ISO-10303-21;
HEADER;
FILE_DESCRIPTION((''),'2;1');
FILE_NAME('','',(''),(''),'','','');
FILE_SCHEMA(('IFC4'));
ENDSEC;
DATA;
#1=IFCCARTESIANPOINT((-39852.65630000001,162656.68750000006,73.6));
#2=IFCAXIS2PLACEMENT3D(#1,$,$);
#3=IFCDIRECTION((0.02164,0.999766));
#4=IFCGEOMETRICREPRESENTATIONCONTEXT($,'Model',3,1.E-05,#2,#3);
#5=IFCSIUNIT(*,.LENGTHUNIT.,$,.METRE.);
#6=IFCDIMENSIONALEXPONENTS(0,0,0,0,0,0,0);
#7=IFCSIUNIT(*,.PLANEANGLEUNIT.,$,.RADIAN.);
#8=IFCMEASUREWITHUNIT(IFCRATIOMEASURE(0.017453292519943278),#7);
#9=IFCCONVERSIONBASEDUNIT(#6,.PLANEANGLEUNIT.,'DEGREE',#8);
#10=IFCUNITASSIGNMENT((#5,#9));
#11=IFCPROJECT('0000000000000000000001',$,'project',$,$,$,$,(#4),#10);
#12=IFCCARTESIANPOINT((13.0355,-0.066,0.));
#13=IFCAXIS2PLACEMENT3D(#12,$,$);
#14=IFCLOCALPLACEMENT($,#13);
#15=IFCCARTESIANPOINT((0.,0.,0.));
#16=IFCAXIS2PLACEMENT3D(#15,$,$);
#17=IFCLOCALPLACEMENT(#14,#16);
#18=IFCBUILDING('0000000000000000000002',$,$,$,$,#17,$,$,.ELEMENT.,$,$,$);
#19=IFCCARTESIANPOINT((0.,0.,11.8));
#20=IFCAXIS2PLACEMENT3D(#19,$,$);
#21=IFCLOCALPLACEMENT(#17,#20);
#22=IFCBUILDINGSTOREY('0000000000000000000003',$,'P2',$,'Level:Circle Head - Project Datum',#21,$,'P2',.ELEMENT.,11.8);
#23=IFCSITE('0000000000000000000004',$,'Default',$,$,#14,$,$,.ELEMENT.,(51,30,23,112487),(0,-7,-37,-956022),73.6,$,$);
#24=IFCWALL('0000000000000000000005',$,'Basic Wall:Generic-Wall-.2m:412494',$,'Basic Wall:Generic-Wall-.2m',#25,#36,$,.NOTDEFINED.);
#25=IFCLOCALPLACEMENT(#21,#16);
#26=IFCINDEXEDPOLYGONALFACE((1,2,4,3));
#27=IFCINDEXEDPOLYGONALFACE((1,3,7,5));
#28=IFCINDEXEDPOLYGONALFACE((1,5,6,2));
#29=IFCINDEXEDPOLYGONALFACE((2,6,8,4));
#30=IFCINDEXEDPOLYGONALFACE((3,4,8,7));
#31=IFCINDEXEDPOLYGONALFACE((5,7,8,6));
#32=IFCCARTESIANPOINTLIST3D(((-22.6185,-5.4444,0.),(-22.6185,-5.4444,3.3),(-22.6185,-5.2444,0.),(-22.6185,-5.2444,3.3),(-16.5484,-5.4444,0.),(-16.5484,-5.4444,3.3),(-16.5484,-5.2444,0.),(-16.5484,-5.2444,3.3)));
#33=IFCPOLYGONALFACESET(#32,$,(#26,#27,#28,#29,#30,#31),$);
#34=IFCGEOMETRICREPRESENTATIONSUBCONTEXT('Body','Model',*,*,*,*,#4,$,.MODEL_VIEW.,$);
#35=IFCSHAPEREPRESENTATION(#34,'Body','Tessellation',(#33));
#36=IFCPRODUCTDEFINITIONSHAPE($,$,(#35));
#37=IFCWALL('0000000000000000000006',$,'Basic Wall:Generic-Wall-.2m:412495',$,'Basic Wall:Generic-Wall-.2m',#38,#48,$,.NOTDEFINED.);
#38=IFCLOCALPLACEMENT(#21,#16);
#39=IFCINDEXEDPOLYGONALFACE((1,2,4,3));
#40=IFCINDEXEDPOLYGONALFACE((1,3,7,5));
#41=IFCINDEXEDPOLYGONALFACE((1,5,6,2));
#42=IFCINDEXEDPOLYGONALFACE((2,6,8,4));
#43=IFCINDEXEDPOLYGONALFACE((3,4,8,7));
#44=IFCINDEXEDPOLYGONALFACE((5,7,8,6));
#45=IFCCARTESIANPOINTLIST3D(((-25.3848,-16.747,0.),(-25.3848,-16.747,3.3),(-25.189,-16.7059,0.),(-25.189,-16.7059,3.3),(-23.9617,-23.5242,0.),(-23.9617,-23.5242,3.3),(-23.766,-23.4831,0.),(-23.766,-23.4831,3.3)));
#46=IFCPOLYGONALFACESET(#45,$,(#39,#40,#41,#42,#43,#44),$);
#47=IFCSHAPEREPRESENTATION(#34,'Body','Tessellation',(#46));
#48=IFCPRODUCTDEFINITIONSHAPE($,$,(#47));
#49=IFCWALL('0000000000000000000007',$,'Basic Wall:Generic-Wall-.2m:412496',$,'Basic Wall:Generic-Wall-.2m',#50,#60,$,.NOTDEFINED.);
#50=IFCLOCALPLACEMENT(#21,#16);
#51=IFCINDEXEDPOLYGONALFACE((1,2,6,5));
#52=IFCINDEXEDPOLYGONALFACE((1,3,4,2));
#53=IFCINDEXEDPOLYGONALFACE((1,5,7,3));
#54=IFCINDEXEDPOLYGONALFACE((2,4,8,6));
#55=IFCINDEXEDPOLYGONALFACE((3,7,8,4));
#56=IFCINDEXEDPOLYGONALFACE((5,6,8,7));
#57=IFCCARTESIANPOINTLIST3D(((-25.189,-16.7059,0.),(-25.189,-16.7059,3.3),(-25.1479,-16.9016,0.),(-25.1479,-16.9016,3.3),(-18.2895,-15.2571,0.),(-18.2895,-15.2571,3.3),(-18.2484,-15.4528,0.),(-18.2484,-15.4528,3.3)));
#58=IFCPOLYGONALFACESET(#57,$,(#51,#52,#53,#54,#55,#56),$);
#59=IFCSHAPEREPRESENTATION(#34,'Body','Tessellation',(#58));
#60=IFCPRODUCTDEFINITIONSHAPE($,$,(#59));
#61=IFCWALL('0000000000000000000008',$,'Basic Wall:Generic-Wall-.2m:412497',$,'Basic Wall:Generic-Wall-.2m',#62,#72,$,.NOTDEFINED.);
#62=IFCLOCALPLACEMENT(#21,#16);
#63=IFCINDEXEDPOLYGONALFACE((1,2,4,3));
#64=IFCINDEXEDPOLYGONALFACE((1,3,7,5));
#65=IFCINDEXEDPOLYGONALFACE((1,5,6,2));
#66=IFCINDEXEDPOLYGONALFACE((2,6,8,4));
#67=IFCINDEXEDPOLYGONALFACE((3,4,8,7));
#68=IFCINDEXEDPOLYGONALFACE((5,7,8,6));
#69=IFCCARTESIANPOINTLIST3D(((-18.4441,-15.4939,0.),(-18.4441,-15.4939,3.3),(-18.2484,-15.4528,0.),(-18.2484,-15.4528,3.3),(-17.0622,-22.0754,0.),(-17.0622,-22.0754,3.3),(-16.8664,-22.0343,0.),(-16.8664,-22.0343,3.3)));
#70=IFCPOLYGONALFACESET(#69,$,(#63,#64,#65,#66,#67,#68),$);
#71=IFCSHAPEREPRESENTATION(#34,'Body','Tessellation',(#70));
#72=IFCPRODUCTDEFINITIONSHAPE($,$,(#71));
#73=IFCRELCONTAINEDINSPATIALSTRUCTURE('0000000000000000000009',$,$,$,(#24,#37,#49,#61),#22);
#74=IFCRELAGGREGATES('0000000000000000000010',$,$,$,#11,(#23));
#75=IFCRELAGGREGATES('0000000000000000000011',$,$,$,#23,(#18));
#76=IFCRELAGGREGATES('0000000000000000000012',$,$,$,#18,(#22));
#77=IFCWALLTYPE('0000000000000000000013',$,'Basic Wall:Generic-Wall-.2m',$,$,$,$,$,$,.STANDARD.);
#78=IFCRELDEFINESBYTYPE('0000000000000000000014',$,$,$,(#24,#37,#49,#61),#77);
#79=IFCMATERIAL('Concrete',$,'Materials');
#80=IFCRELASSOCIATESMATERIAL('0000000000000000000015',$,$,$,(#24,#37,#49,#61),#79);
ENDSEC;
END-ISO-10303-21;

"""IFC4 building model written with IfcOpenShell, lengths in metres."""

from ifc_helpers import new_model, entity, si_unit, converted_unit, direction, frame, origin, place, context, subcontext, project, spatial, indexed_curve, outline, extrude, material, type_object, element, save


model = new_model("IFC4")

# Units and contexts
model_context = context("Model", 3, precision=1e-05, world=frame((-39852.65630000001, 162656.68750000006, 73.6)), true_north=direction((0.02164, 0.999766)))
body_context = subcontext(model_context, "Body", "Model", "MODEL_VIEW")
ifc_project = project(units=[si_unit("LENGTHUNIT", "METRE"), converted_unit("PLANEANGLEUNIT", "DEGREE", entity("IfcRatioMeasure", 0.017453292519943278), si_unit("PLANEANGLEUNIT", "RADIAN"), dimensions=[0, 0, 0, 0, 0, 0, 0])], contexts=[model_context])

# Site, building, storey
site_placement = place(None, frame((13.0355, -0.066, 0.0)))
site = spatial("IfcSite", under=ifc_project, at=site_placement, Name="Default", CompositionType="ELEMENT", RefLatitude=(51, 30, 23, 112487), RefLongitude=(0, -7, -37, -956022), RefElevation=73.6)
building_placement = place(site_placement, origin())
building = spatial("IfcBuilding", under=site, at=building_placement, CompositionType="ELEMENT")
storey_placement = place(building_placement, frame((0.0, 0.0, 11.8)))
storey = spatial("IfcBuildingStorey", under=building, at=storey_placement, Name="P2", ObjectType="Level:Circle Head - Project Datum", LongName="P2", CompositionType="ELEMENT", Elevation=11.8)

# Shared definitions
ifc_material = material(Name="Concrete", Category="Materials")

# Walls
wall_type_1 = type_object("IfcWallType", Name="Basic Wall:Generic-Wall-.2m", PredefinedType="STANDARD")
wall_1_placement = place(storey_placement, frame((-22.6185, -5.3444, 0.0)))
element("IfcWall", 1, at=wall_1_placement, inside=storey, type_object=wall_type_1, material=ifc_material, Name="Basic Wall:Generic-Wall-.2m:412494", ObjectType="Basic Wall:Generic-Wall-.2m", PredefinedType="NOTDEFINED", context=body_context, shape_type="SweptSolid", body=[
    extrude(outline(indexed_curve([(6.0701, 0.1), (0.0, 0.1), (0.0, -0.1), (6.0701, -0.1), (6.0701, 0.1)], self_intersect=False)), origin(), (0.0, 0.0, 1.0), 3.3),
])
wall_2_placement = place(storey_placement, frame((-23.8638, -23.5036, 0.0), z_axis=(0.0, 0.0, 1.0), x_axis=(-0.2055, 0.978657, 0.0)))
element("IfcWall", 2, at=wall_2_placement, inside=storey, type_object=wall_type_1, material=ifc_material, Name="Basic Wall:Generic-Wall-.2m:412495", ObjectType="Basic Wall:Generic-Wall-.2m", PredefinedType="NOTDEFINED", context=body_context, shape_type="SweptSolid", body=[
    extrude(outline(indexed_curve([(6.925, 0.1), (0.0, 0.1), (0.0, -0.1), (6.925, -0.1), (6.925, 0.1)], self_intersect=False)), origin(), (0.0, 0.0, 1.0), 3.3),
])
wall_3_placement = place(storey_placement, frame((-25.1685, -16.8038, 0.0), z_axis=(0.0, 0.0, 1.0), x_axis=(0.978657, 0.2055, 0.0)))
element("IfcWall", 3, at=wall_3_placement, inside=storey, type_object=wall_type_1, material=ifc_material, Name="Basic Wall:Generic-Wall-.2m:412496", ObjectType="Basic Wall:Generic-Wall-.2m", PredefinedType="NOTDEFINED", context=body_context, shape_type="SweptSolid", body=[
    extrude(outline(indexed_curve([(7.05, 0.1), (0.0, 0.1), (0.0, -0.1), (7.05, -0.1), (7.05, 0.1)], self_intersect=False)), origin(), (0.0, 0.0, 1.0), 3.3),
])
wall_4_placement = place(storey_placement, frame((-18.3463, -15.4734, 0.0), z_axis=(0.0, 0.0, 1.0), x_axis=(0.2055, -0.978657, 0.0)))
element("IfcWall", 4, at=wall_4_placement, inside=storey, type_object=wall_type_1, material=ifc_material, Name="Basic Wall:Generic-Wall-.2m:412497", ObjectType="Basic Wall:Generic-Wall-.2m", PredefinedType="NOTDEFINED", context=body_context, shape_type="SweptSolid", body=[
    extrude(outline(indexed_curve([(6.725, 0.1), (0.0, 0.1), (0.0, -0.1), (6.725, -0.1), (6.725, 0.1)], self_intersect=False)), origin(), (0.0, 0.0, 1.0), 3.3),
])

save(model, "model.ifc")
